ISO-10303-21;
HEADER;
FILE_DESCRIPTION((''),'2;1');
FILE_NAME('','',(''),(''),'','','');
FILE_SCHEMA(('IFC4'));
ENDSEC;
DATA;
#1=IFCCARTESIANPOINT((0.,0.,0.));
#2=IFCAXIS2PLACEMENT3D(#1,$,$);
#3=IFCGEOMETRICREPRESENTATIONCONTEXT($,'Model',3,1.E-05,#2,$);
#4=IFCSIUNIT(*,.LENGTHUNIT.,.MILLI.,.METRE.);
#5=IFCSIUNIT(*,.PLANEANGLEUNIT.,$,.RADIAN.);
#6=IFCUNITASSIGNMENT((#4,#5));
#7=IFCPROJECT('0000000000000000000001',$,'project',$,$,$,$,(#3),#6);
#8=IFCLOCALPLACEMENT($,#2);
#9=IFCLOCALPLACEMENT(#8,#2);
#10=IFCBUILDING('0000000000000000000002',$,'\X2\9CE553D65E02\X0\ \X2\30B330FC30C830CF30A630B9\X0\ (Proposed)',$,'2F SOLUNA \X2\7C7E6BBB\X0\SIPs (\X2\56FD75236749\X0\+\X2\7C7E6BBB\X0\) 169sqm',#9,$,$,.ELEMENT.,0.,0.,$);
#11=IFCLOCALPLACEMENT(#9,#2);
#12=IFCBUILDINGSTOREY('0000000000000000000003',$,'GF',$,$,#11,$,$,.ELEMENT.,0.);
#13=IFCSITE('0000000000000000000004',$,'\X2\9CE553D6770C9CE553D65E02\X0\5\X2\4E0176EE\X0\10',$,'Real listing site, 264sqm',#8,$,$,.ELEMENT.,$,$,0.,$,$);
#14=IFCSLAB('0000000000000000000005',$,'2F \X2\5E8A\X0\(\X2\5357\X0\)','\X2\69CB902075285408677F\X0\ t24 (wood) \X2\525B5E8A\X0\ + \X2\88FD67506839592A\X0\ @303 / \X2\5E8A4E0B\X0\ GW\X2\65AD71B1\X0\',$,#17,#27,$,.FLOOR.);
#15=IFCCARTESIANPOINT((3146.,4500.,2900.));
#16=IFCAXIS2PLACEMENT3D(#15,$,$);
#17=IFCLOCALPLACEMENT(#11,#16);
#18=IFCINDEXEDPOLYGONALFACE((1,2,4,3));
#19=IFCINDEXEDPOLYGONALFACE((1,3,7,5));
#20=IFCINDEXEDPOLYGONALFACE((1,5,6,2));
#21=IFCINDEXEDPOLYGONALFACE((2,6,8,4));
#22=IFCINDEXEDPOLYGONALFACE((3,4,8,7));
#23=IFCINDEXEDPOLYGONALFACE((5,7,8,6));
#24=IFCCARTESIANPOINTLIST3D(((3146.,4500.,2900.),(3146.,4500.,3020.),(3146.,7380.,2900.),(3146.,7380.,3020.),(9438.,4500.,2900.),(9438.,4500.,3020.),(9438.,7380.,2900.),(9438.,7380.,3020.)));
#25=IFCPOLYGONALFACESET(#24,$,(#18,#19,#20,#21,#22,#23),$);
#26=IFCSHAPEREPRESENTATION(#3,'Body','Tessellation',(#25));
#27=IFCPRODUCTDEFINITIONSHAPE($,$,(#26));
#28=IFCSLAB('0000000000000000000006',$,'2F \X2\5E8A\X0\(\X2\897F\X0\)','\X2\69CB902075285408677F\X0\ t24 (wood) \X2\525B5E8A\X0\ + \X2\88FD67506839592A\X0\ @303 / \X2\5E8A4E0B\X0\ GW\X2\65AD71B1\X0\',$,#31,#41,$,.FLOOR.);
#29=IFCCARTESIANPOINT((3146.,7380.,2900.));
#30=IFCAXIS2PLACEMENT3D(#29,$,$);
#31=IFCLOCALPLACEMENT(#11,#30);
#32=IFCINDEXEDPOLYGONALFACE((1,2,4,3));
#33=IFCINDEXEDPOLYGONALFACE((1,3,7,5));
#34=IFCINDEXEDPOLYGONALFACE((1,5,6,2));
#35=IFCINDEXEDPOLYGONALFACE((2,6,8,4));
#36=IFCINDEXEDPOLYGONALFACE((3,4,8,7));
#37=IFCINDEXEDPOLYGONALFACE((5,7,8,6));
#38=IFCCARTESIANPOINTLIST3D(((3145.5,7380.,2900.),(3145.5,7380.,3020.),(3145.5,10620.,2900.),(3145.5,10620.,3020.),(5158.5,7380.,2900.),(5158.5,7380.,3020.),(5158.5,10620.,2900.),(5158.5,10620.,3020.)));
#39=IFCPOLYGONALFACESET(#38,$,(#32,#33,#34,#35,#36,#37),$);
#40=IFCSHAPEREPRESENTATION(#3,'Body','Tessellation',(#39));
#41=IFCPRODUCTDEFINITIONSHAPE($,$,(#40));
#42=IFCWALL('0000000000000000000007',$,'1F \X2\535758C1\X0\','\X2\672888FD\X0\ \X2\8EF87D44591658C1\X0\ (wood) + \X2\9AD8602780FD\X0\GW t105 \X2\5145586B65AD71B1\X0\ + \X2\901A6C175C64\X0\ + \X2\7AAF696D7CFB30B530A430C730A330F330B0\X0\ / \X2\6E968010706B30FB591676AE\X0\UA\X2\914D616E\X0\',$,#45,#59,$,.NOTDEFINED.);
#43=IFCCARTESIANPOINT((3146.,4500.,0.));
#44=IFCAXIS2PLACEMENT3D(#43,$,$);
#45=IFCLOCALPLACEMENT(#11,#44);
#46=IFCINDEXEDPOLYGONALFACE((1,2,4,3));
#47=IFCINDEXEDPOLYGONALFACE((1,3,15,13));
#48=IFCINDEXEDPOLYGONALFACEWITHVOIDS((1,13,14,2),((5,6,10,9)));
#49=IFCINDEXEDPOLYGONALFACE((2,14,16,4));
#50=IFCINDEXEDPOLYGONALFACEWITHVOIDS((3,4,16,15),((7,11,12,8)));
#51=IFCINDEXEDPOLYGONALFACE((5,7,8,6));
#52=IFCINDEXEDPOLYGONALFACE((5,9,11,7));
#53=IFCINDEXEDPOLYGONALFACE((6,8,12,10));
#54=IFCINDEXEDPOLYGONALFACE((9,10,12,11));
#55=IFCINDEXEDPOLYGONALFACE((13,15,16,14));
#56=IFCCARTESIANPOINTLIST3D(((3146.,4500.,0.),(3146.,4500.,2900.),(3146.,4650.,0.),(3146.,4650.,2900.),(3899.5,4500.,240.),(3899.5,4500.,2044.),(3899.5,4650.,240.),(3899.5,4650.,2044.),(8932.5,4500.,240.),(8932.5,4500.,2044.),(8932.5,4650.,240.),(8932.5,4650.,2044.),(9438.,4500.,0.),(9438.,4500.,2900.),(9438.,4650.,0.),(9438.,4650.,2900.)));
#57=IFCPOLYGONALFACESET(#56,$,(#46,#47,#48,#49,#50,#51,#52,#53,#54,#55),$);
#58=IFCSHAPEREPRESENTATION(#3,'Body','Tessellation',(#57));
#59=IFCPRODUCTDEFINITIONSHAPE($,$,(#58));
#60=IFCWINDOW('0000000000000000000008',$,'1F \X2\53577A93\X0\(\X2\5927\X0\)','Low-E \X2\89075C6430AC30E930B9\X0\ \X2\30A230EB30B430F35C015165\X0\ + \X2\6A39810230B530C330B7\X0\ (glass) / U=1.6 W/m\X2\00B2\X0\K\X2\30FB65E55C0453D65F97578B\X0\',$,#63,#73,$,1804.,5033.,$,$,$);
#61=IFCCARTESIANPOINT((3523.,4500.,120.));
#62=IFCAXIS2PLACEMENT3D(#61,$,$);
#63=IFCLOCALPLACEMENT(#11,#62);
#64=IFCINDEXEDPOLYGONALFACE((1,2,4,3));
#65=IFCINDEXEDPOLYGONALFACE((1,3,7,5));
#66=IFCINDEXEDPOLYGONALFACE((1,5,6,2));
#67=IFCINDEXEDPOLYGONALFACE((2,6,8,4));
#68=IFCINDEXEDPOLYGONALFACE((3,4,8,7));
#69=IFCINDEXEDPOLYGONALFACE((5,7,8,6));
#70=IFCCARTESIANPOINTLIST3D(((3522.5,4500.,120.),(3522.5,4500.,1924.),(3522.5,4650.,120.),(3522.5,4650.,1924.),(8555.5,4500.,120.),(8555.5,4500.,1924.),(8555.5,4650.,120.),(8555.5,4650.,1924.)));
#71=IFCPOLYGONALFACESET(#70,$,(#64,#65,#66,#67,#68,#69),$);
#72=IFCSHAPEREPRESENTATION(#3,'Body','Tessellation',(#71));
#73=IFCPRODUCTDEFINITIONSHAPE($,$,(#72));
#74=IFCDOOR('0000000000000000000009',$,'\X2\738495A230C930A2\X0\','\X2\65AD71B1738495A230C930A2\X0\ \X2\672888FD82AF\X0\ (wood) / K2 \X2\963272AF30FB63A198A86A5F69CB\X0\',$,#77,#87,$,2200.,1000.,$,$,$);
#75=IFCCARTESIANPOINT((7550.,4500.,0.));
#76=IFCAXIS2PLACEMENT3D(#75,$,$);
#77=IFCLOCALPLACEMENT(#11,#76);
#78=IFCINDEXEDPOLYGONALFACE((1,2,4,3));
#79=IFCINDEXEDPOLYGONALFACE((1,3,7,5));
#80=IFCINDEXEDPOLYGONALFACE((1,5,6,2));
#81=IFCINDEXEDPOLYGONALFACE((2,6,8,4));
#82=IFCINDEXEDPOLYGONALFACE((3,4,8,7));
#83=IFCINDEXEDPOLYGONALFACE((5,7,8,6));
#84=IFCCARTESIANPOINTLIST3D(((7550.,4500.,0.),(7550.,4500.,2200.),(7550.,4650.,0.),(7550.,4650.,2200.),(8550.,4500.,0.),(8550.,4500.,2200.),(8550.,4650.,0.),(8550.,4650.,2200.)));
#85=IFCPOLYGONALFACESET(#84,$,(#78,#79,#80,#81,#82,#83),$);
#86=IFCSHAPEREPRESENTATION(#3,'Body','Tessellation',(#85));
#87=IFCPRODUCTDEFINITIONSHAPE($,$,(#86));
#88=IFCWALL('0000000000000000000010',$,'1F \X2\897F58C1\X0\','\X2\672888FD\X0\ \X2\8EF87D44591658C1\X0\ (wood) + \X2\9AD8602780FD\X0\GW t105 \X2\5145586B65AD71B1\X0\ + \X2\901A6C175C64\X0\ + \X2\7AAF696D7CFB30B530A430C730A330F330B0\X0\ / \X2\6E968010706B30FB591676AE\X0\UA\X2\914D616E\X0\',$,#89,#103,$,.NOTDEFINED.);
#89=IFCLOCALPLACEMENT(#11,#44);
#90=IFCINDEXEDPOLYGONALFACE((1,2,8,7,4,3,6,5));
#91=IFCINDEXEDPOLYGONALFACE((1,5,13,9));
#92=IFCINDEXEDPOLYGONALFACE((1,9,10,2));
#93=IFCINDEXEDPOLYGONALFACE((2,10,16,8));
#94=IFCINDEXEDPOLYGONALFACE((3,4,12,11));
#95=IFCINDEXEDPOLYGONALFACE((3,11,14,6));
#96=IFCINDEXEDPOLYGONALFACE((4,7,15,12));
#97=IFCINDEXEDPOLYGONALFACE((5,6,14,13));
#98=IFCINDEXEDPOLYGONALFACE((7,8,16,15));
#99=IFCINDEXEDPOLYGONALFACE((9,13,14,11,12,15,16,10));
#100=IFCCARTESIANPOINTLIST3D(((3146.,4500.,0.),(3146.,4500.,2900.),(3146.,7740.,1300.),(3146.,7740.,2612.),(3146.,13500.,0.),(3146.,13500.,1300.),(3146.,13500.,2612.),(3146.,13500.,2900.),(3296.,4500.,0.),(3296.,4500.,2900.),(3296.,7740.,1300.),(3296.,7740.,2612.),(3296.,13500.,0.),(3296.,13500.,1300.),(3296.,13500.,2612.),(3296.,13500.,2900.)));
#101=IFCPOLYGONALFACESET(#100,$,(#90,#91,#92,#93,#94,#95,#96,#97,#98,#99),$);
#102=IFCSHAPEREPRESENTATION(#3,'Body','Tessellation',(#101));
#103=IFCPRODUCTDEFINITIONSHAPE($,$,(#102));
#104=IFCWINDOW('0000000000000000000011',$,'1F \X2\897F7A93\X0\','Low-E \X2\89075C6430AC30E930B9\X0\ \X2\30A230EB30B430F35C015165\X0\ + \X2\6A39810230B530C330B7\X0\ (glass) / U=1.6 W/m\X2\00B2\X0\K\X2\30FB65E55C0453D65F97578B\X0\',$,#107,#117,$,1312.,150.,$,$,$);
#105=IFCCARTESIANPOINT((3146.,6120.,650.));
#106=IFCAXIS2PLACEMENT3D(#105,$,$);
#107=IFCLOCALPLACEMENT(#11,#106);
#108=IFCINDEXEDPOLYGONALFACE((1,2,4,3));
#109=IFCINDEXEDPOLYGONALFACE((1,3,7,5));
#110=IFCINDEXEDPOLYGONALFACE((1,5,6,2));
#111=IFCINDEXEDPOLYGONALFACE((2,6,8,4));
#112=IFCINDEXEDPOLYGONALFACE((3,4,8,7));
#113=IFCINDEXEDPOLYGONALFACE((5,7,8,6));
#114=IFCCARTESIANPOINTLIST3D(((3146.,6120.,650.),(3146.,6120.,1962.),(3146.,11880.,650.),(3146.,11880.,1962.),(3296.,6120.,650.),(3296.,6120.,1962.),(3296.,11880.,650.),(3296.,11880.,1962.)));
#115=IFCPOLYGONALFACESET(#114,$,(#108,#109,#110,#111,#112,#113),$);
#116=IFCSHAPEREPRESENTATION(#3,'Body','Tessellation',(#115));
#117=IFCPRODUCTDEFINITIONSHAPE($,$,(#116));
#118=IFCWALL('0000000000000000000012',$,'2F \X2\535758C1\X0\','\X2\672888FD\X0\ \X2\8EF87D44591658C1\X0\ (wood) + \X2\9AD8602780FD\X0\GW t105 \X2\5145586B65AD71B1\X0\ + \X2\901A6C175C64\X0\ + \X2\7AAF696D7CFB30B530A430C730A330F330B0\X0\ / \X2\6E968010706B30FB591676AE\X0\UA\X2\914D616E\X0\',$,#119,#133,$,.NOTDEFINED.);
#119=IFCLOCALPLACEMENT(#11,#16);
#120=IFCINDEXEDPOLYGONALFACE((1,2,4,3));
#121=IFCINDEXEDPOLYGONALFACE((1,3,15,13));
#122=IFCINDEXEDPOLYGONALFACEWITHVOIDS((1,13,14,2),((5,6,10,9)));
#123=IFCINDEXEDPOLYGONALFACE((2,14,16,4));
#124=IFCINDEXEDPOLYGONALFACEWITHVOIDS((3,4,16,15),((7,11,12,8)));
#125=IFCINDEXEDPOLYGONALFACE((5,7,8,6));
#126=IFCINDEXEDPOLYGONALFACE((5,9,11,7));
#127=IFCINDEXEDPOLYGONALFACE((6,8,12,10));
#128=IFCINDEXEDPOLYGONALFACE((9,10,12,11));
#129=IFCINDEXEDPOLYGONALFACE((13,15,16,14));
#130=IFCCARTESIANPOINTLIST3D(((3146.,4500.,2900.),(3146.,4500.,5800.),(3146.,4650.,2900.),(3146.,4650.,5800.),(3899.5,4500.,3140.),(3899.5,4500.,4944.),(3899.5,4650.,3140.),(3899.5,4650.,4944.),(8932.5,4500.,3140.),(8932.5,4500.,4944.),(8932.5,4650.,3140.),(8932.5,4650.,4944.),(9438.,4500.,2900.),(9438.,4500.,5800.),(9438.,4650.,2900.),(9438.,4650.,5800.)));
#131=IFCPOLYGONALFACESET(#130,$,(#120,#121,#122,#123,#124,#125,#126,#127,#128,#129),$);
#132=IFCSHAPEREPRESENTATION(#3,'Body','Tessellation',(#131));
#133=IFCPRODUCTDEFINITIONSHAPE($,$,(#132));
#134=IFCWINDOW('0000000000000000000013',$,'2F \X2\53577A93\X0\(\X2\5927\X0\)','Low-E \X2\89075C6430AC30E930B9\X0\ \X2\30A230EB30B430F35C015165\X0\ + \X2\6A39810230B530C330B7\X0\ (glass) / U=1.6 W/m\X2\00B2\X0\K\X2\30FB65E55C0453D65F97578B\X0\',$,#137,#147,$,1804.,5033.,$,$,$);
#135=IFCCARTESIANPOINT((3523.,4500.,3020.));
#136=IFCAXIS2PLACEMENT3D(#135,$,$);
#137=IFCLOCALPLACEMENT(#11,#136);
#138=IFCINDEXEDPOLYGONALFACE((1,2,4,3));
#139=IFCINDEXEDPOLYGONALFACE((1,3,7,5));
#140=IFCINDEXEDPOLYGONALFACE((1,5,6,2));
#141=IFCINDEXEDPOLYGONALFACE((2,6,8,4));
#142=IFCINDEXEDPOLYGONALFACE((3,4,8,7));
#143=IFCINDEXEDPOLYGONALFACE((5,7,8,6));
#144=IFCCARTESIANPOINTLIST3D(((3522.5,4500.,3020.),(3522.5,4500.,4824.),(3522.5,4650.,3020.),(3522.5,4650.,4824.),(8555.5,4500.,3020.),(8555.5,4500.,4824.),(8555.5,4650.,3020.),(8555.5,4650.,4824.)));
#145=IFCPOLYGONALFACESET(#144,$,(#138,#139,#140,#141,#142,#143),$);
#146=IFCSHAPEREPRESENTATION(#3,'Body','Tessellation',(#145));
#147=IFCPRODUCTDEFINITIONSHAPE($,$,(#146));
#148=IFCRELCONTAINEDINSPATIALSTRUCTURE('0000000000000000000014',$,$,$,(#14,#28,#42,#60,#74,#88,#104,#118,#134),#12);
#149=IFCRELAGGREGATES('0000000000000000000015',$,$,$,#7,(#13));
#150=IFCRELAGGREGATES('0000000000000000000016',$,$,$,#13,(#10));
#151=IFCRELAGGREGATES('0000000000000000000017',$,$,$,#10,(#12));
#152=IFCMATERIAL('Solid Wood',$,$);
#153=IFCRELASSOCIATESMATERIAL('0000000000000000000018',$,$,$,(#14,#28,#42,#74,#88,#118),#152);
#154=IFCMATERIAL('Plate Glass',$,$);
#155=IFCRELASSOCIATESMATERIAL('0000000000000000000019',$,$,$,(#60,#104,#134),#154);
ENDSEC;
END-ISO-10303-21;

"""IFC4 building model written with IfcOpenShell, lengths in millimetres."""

from ifc_helpers import new_model, si_unit, frame, frame_2d, origin, place, context, project, spatial, rectangle, extrude, material, element, fill, save


model = new_model("IFC4")

# Units and contexts
model_context = context("Model", 3, precision=1e-05, world=origin())
ifc_project = project(units=[si_unit("LENGTHUNIT", "METRE", prefix="MILLI"), si_unit("PLANEANGLEUNIT", "RADIAN")], contexts=[model_context])

# Site, building, storey
site_placement = place(None, origin())
site = spatial("IfcSite", under=ifc_project, at=site_placement, Name="鳥取県鳥取市5丁目10", ObjectType="Real listing site, 264sqm", CompositionType="ELEMENT", RefElevation=0.0)
building_placement = place(site_placement, origin())
building = spatial("IfcBuilding", under=site, at=building_placement, Name="鳥取市 コートハウス (Proposed)", ObjectType="2F SOLUNA 籾殻SIPs (国産杉+籾殻) 169sqm", CompositionType="ELEMENT", ElevationOfRefHeight=0.0, ElevationOfTerrain=0.0)
storey_placement = place(building_placement, origin())
storey = spatial("IfcBuildingStorey", under=building, at=storey_placement, Name="GF", CompositionType="ELEMENT", Elevation=0.0)

# Slabs
ifc_material_1 = material(Name="Solid Wood")
slab_1_placement = place(storey_placement, frame((3146.0, 4500.0, 2900.0)))
element("IfcSlab", 1, at=slab_1_placement, inside=storey, material=ifc_material_1, Name="2F 床(南)", Description="構造用合板 t24 (wood) 剛床 + 製材根太 @303 / 床下 GW断熱", PredefinedType="FLOOR", context=model_context, shape_type="SweptSolid", body=[
    extrude(rectangle(XDim=6292.0, YDim=2880.0, at=frame_2d((3146.0, 1440.0))), frame((3146.0, 4500.0, 2900.0)), (0.0, 0.0, 1.0), 120.0),
])
slab_2_placement = place(storey_placement, frame((3146.0, 7380.0, 2900.0)))
element("IfcSlab", 2, at=slab_2_placement, inside=storey, material=ifc_material_1, Name="2F 床(西)", Description="構造用合板 t24 (wood) 剛床 + 製材根太 @303 / 床下 GW断熱", PredefinedType="FLOOR", context=model_context, shape_type="SweptSolid", body=[
    extrude(rectangle(XDim=2013.0, YDim=3240.0, at=frame_2d((1006.0, 1620.0))), frame((3146.0, 7380.0, 2900.0)), (0.0, 0.0, 1.0), 120.0),
])

# Wall, openings, window, door
wall_1_placement = place(storey_placement, frame((3146.0, 4500.0, 0.0)))
wall_1 = element("IfcWall", 3, at=wall_1_placement, inside=storey, material=ifc_material_1, Name="1F 南壁", Description="木製 軸組外壁 (wood) + 高性能GW t105 充填断熱 + 通気層 + 窯業系サイディング / 準耐火・外皮UA配慮", PredefinedType="NOTDEFINED", context=model_context, shape_type="SweptSolid", body=[
    extrude(rectangle(XDim=6292.0, YDim=150.0, at=frame_2d((3146.0, 75.0))), frame((3146.0, 4500.0, 0.0)), (0.0, 0.0, 1.0), 2900.0),
])
opening_1_placement = place(storey_placement, frame((3523.0, 4500.0, 120.0)))
opening_1 = element("IfcOpeningElement", 4, at=opening_1_placement, cuts=wall_1, PredefinedType="NOTDEFINED", context=model_context, shape_type="SweptSolid", body=[
    extrude(rectangle(XDim=5033.0, YDim=150.0, at=frame_2d((2516.0, 75.0))), frame((3523.0, 4500.0, 120.0)), (0.0, 0.0, 1.0), 1804.0),
])
opening_2_placement = place(storey_placement, frame((7550.0, 4500.0, 0.0)))
opening_2 = element("IfcOpeningElement", 5, at=opening_2_placement, cuts=wall_1, PredefinedType="NOTDEFINED", context=model_context, shape_type="SweptSolid", body=[
    extrude(rectangle(XDim=1000.0, YDim=150.0, at=frame_2d((500.0, 75.0))), frame((7550.0, 4500.0, 0.0)), (0.0, 0.0, 1.0), 2200.0),
])
ifc_material_2 = material(Name="Plate Glass")
window_1_placement = place(storey_placement, frame((3523.0, 4500.0, 120.0)))
window_1 = element("IfcWindow", 6, at=window_1_placement, inside=storey, material=ifc_material_2, Name="1F 南窓(大)", Description="Low-E 複層ガラス アルゴン封入 + 樹脂サッシ (glass) / U=1.6 W/m²K・日射取得型", OverallHeight=1804.0, OverallWidth=5033.0, context=model_context, shape_type="SweptSolid", body=[
    extrude(rectangle(XDim=5033.0, YDim=150.0, at=frame_2d((2516.0, 75.0))), frame((3523.0, 4500.0, 120.0)), (0.0, 0.0, 1.0), 1804.0),
])
fill(opening_1, window_1)
door_placement = place(storey_placement, frame((7550.0, 4500.0, 0.0)))
door = element("IfcDoor", 7, at=door_placement, inside=storey, material=ifc_material_1, Name="玄関ドア", Description="断熱玄関ドア 木製芯 (wood) / K2 防犯・採風機構", OverallHeight=2200.0, OverallWidth=1000.0, context=model_context, shape_type="SweptSolid", body=[
    extrude(rectangle(XDim=1000.0, YDim=150.0, at=frame_2d((500.0, 75.0))), frame((7550.0, 4500.0, 0.0)), (0.0, 0.0, 1.0), 2200.0),
])
fill(opening_2, door)

# Walls, openings, windows
wall_2_placement = place(storey_placement, frame((3146.0, 4500.0, 0.0)))
wall_2 = element("IfcWall", 8, at=wall_2_placement, inside=storey, material=ifc_material_1, Name="1F 西壁", Description="木製 軸組外壁 (wood) + 高性能GW t105 充填断熱 + 通気層 + 窯業系サイディング / 準耐火・外皮UA配慮", PredefinedType="NOTDEFINED", context=model_context, shape_type="SweptSolid", body=[
    extrude(rectangle(XDim=150.0, YDim=9000.0, at=frame_2d((75.0, 4500.0))), frame((3146.0, 4500.0, 0.0)), (0.0, 0.0, 1.0), 2900.0),
])
opening_3_placement = place(storey_placement, frame((3146.0, 6120.0, 650.0)))
opening_3 = element("IfcOpeningElement", 9, at=opening_3_placement, cuts=wall_2, PredefinedType="NOTDEFINED", context=model_context, shape_type="SweptSolid", body=[
    extrude(rectangle(XDim=150.0, YDim=5760.0, at=frame_2d((75.0, 2880.0))), frame((3146.0, 6120.0, 650.0)), (0.0, 0.0, 1.0), 1312.0),
])
window_2_placement = place(storey_placement, frame((3146.0, 6120.0, 650.0)))
window_2 = element("IfcWindow", 10, at=window_2_placement, inside=storey, material=ifc_material_2, Name="1F 西窓", Description="Low-E 複層ガラス アルゴン封入 + 樹脂サッシ (glass) / U=1.6 W/m²K・日射取得型", OverallHeight=1312.0, OverallWidth=150.0, context=model_context, shape_type="SweptSolid", body=[
    extrude(rectangle(XDim=150.0, YDim=5760.0, at=frame_2d((75.0, 2880.0))), frame((3146.0, 6120.0, 650.0)), (0.0, 0.0, 1.0), 1312.0),
])
fill(opening_3, window_2)
wall_3_placement = place(storey_placement, frame((3146.0, 4500.0, 2900.0)))
wall_3 = element("IfcWall", 11, at=wall_3_placement, inside=storey, material=ifc_material_1, Name="2F 南壁", Description="木製 軸組外壁 (wood) + 高性能GW t105 充填断熱 + 通気層 + 窯業系サイディング / 準耐火・外皮UA配慮", PredefinedType="NOTDEFINED", context=model_context, shape_type="SweptSolid", body=[
    extrude(rectangle(XDim=6292.0, YDim=150.0, at=frame_2d((3146.0, 75.0))), frame((3146.0, 4500.0, 2900.0)), (0.0, 0.0, 1.0), 2900.0),
])
opening_4_placement = place(storey_placement, frame((3523.0, 4500.0, 3020.0)))
opening_4 = element("IfcOpeningElement", 12, at=opening_4_placement, cuts=wall_3, PredefinedType="NOTDEFINED", context=model_context, shape_type="SweptSolid", body=[
    extrude(rectangle(XDim=5033.0, YDim=150.0, at=frame_2d((2516.0, 75.0))), frame((3523.0, 4500.0, 3020.0)), (0.0, 0.0, 1.0), 1804.0),
])
window_3_placement = place(storey_placement, frame((3523.0, 4500.0, 3020.0)))
window_3 = element("IfcWindow", 13, at=window_3_placement, inside=storey, material=ifc_material_2, Name="2F 南窓(大)", Description="Low-E 複層ガラス アルゴン封入 + 樹脂サッシ (glass) / U=1.6 W/m²K・日射取得型", OverallHeight=1804.0, OverallWidth=5033.0, context=model_context, shape_type="SweptSolid", body=[
    extrude(rectangle(XDim=5033.0, YDim=150.0, at=frame_2d((2516.0, 75.0))), frame((3523.0, 4500.0, 3020.0)), (0.0, 0.0, 1.0), 1804.0),
])
fill(opening_4, window_3)

save(model, "model.ifc")
